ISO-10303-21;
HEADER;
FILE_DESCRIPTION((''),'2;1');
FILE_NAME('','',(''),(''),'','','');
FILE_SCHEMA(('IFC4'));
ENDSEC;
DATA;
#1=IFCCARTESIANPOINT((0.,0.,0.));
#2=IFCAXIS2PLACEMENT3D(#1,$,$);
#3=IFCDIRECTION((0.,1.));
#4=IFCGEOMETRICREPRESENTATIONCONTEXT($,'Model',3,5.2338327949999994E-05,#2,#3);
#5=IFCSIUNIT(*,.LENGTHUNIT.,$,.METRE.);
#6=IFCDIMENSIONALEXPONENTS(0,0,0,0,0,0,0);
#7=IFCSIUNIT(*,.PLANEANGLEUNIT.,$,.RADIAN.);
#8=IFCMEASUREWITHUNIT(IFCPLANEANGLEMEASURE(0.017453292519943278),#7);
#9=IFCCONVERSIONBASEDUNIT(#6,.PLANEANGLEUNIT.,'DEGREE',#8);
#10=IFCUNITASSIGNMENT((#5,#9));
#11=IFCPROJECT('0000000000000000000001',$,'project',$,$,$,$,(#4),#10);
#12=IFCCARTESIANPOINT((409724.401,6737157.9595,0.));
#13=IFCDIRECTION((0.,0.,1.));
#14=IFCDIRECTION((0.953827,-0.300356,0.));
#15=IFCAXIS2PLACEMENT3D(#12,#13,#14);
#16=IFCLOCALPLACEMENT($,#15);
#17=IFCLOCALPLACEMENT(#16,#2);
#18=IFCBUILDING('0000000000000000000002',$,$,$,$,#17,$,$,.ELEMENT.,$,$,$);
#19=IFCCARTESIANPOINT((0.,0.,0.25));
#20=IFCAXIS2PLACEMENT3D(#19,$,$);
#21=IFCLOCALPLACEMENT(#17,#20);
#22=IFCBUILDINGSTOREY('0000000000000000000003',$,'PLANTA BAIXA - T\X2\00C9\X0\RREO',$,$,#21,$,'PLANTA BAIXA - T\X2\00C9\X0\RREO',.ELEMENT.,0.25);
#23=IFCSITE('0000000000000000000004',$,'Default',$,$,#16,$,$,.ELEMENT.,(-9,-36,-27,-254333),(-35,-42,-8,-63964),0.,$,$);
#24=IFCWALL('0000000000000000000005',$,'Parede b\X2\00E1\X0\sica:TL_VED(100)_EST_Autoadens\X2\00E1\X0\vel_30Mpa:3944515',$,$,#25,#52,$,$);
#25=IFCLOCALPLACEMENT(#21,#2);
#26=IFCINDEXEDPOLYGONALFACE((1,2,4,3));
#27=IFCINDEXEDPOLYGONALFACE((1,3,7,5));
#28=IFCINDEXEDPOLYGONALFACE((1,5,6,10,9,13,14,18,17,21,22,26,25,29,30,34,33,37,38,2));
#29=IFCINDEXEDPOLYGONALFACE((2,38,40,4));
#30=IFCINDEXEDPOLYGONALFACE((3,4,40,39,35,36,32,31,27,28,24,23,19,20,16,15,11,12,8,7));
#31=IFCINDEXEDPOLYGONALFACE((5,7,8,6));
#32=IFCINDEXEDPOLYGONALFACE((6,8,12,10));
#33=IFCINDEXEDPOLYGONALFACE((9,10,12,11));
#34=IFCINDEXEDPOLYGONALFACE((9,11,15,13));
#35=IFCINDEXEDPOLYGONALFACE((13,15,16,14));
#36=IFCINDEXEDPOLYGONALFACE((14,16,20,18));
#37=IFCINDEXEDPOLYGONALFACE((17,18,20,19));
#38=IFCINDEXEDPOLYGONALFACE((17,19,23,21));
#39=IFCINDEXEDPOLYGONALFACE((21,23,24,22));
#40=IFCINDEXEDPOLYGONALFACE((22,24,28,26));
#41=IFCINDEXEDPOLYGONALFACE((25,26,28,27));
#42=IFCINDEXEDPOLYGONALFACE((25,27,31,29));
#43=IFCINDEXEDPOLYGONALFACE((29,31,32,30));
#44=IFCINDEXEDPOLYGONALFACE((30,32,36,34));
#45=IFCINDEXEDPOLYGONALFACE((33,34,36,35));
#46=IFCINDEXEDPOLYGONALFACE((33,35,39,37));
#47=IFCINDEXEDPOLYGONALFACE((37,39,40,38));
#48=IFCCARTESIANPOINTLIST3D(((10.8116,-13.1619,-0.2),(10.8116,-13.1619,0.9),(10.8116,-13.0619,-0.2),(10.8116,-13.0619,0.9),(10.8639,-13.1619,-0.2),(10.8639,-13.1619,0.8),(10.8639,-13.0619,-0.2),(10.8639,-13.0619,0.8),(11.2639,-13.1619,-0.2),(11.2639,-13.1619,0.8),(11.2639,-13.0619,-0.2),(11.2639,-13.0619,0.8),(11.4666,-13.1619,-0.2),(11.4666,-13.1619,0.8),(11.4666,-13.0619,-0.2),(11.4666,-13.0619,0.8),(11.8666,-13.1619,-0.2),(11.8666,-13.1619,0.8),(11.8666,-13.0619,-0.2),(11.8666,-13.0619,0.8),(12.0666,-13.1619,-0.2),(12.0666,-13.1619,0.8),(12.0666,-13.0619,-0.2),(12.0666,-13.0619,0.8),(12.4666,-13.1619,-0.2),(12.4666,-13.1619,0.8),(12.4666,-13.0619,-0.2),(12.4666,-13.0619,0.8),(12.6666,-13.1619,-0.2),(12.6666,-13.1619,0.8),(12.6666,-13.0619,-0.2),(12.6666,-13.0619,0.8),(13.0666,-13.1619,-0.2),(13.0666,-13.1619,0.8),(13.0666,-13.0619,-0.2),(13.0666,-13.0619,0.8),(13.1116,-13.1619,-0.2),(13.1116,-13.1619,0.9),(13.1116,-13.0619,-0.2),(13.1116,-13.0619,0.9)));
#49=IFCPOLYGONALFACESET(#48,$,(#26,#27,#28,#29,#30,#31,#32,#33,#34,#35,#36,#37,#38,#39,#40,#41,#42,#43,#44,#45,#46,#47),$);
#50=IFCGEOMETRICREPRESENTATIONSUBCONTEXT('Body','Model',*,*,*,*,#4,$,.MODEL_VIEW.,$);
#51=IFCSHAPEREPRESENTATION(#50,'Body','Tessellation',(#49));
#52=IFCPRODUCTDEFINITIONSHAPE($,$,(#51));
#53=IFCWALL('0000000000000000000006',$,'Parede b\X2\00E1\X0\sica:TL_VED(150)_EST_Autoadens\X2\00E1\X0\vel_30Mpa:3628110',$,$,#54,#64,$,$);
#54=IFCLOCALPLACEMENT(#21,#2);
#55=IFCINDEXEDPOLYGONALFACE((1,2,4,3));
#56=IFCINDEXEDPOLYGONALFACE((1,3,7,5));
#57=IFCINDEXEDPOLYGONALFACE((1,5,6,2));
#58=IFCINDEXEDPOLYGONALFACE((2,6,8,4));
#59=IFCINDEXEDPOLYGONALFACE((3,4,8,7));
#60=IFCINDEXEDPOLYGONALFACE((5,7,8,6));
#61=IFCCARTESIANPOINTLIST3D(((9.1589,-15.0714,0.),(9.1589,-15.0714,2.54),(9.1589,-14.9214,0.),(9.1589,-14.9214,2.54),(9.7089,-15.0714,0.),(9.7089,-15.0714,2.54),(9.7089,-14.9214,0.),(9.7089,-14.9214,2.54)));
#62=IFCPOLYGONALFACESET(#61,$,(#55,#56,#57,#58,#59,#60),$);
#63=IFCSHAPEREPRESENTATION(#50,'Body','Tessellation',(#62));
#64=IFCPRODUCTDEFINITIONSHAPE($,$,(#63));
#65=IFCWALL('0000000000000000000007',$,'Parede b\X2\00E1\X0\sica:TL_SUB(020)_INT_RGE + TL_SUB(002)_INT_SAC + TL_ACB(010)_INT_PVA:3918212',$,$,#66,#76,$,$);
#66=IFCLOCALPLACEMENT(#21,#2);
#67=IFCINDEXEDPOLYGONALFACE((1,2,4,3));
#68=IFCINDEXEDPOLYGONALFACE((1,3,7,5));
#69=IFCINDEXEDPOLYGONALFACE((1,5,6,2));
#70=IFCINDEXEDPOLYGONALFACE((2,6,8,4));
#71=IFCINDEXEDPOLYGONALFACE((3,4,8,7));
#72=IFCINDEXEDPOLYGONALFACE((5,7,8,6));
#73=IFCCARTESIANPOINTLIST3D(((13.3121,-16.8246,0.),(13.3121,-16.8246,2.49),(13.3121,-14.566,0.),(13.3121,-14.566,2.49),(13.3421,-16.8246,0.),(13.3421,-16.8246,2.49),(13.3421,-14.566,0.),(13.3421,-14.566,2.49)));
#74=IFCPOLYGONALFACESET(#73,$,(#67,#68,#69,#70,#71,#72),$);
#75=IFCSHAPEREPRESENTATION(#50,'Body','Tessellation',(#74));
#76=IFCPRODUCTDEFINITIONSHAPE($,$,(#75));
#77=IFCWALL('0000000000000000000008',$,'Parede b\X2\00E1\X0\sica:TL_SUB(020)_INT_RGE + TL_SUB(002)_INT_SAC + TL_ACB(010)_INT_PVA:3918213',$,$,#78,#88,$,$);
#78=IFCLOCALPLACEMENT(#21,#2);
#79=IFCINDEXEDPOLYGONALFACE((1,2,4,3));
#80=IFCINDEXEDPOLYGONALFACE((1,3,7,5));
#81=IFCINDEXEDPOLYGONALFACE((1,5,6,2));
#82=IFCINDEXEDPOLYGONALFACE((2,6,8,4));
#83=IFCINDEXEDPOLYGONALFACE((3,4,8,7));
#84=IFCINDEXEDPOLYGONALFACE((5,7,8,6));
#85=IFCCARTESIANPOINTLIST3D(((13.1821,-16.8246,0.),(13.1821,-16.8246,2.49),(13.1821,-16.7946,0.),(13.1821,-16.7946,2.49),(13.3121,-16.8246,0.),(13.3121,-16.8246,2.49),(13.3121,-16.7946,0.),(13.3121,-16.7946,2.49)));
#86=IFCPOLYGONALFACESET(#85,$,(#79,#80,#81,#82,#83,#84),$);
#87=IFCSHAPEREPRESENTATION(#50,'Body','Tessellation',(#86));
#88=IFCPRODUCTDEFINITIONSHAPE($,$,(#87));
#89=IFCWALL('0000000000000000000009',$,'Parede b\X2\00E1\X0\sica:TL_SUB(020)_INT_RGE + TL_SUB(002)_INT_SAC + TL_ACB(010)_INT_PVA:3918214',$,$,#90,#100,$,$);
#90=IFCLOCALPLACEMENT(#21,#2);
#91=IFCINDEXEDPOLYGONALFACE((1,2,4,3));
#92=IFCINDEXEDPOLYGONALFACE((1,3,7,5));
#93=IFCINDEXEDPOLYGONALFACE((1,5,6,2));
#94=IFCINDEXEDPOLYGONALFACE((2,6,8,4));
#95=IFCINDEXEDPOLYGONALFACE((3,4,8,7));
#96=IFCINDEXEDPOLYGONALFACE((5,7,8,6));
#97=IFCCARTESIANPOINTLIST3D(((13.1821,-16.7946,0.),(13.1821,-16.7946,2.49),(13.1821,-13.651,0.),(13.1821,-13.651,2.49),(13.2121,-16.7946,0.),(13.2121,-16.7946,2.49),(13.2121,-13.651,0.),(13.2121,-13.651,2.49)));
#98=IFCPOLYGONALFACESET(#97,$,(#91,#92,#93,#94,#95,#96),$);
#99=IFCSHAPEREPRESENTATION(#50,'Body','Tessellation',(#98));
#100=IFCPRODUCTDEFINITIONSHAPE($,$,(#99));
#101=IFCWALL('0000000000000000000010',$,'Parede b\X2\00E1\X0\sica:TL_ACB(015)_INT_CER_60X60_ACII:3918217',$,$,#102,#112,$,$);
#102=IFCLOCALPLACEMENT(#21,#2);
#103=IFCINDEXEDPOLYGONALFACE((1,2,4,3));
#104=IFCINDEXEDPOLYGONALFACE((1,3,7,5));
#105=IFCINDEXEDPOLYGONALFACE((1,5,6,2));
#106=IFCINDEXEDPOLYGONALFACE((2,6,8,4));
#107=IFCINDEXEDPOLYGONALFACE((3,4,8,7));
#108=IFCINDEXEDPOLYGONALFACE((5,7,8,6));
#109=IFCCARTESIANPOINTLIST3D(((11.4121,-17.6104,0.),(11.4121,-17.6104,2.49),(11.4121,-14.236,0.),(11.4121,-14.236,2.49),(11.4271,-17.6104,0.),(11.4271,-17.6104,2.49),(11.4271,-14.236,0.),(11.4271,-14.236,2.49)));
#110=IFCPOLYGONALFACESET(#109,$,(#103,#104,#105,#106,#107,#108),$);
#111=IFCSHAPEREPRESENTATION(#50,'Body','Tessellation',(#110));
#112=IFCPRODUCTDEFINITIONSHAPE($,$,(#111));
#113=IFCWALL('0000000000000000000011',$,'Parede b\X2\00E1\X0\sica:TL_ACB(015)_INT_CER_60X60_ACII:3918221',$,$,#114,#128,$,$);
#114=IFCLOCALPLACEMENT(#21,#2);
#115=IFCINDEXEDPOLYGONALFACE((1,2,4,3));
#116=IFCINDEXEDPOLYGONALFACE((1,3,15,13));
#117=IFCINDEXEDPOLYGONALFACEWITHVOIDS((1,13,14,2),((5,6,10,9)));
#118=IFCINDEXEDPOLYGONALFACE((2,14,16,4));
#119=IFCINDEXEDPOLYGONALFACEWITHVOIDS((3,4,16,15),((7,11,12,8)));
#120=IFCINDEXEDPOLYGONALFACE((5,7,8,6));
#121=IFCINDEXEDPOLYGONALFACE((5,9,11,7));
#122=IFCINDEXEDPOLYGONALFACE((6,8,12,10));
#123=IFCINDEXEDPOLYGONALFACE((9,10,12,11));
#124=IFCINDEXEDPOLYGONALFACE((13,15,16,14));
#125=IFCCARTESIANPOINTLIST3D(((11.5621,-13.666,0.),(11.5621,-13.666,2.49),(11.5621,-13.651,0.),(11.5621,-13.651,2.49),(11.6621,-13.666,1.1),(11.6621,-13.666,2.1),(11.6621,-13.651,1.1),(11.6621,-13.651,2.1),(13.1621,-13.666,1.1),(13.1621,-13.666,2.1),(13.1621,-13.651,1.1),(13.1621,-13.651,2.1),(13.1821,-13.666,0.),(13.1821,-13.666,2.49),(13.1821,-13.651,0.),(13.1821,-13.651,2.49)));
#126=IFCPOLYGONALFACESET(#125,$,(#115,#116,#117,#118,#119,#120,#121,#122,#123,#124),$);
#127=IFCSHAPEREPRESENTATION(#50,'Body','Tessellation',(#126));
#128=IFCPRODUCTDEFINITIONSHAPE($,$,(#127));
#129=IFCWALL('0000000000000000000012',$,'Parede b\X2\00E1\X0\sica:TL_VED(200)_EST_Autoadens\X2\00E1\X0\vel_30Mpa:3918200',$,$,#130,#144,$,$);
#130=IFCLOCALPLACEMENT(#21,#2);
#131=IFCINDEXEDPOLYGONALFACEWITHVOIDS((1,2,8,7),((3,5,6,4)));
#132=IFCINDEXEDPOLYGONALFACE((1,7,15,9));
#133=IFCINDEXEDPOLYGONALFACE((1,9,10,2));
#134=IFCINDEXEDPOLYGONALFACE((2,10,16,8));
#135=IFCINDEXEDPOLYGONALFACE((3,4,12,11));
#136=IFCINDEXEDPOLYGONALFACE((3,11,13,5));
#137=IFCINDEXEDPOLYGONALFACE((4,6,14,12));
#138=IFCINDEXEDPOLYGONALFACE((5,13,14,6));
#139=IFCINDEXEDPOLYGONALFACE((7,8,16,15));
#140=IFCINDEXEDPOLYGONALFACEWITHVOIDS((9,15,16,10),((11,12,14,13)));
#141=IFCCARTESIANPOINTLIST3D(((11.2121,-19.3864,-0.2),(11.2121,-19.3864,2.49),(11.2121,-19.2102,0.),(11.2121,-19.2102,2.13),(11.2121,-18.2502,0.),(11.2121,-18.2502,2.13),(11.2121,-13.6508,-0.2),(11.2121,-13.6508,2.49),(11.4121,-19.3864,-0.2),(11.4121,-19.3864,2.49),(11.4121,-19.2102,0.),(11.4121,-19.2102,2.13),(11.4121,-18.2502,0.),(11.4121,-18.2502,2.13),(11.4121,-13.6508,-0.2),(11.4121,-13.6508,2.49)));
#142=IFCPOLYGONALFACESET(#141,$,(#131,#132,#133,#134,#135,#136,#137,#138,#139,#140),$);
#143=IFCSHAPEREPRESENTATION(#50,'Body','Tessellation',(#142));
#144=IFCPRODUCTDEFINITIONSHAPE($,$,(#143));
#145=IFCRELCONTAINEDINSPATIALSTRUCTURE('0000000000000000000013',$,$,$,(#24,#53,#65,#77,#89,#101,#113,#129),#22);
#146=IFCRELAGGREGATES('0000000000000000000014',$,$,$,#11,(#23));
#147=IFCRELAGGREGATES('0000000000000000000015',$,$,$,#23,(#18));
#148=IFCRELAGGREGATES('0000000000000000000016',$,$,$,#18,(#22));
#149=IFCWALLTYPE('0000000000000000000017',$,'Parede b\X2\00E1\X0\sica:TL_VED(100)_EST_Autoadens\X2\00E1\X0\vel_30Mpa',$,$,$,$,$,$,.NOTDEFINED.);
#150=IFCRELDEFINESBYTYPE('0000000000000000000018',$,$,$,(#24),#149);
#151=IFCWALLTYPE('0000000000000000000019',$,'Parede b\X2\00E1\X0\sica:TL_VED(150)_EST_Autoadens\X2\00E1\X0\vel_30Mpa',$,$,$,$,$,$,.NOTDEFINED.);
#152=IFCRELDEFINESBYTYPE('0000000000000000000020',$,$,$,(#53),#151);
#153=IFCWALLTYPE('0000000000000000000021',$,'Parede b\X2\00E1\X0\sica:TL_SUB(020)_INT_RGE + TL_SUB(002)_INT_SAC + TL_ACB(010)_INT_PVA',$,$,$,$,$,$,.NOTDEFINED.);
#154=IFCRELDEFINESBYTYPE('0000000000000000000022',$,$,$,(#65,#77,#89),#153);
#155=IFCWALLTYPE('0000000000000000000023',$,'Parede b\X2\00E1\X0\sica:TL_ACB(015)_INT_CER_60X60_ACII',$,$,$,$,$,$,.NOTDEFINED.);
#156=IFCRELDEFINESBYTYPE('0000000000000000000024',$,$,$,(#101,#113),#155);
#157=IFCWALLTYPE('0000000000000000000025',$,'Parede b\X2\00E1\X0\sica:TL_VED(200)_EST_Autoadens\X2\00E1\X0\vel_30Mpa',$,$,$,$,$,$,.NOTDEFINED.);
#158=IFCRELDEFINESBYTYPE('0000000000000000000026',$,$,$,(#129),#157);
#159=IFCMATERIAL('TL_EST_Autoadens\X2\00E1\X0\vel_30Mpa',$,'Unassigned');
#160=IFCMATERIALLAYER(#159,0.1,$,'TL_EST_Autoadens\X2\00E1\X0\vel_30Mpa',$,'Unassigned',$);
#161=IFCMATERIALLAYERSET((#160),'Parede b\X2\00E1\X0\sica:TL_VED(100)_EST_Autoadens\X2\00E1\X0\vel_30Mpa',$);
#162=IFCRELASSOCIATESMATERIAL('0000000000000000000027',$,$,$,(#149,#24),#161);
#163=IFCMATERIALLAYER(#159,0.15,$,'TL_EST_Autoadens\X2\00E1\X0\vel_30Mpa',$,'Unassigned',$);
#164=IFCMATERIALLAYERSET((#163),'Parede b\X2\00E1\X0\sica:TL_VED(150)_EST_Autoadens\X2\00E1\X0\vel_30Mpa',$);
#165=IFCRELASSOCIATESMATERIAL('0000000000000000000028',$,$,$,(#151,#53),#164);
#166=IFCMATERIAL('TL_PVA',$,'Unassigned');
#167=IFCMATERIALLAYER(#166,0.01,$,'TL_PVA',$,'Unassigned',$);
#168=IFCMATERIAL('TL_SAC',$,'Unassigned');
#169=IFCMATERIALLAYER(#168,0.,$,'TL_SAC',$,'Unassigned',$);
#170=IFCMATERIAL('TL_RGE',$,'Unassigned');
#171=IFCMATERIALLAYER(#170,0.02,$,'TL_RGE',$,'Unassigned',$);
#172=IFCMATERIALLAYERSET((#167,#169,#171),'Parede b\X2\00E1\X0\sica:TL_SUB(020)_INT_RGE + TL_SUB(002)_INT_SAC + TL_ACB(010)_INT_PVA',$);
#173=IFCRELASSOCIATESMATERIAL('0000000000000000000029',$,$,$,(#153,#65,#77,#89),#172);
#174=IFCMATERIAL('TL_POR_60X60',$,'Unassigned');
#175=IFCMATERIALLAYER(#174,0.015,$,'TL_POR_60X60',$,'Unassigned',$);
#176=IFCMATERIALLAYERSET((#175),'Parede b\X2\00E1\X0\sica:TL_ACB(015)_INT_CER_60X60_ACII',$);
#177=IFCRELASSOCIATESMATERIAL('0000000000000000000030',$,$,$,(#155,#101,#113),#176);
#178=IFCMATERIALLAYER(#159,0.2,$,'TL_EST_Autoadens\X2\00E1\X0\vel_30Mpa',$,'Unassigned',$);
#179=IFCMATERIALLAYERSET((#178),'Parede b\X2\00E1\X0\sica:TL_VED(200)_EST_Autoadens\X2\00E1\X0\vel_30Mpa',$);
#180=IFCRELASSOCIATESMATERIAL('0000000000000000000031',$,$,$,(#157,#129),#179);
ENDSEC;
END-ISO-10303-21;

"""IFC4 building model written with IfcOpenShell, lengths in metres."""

from ifc_helpers import new_model, entity, si_unit, converted_unit, direction, frame, frame_2d, origin, place, context, subcontext, project, spatial, polyline, rectangle, extrude, clip, bounded_halfspace, material, layer, layer_set, layer_usage, type_object, element, save


model = new_model("IFC4")

# Units and contexts
model_context = context("Model", 3, precision=5.2338327949999994e-05, world=origin(), true_north=direction((0.0, 1.0)))
body_context = subcontext(model_context, "Body", "Model", "MODEL_VIEW")
ifc_project = project(units=[si_unit("LENGTHUNIT", "METRE"), converted_unit("PLANEANGLEUNIT", "DEGREE", entity("IfcPlaneAngleMeasure", 0.017453292519943278), si_unit("PLANEANGLEUNIT", "RADIAN"), dimensions=[0, 0, 0, 0, 0, 0, 0])], contexts=[model_context])

# Site, building, storey
site_placement = place(None, frame((409724.401, 6737157.9595, 0.0), z_axis=(0.0, 0.0, 1.0), x_axis=(0.953827, -0.300356, 0.0)))
site = spatial("IfcSite", under=ifc_project, at=site_placement, Name="Default", CompositionType="ELEMENT", RefLatitude=(-9, -36, -27, -254333), RefLongitude=(-35, -42, -8, -63964), RefElevation=0.0)
building_placement = place(site_placement, origin())
building = spatial("IfcBuilding", under=site, at=building_placement, CompositionType="ELEMENT")
storey_placement = place(building_placement, frame((0.0, 0.0, 0.25)))
storey = spatial("IfcBuildingStorey", under=building, at=storey_placement, Name="PLANTA BAIXA - TÉRREO", LongName="PLANTA BAIXA - TÉRREO", CompositionType="ELEMENT", Elevation=0.25)

# Shared definitions
ifc_material_1 = material(Name="TL_EST_Autoadensável_30Mpa", Category="Unassigned")
ifc_layer_1 = layer(ifc_material_1, 0.1, Name="TL_EST_Autoadensável_30Mpa", Category="Unassigned")
ifc_layer_set_1 = layer_set([ifc_layer_1], Name="Parede básica:TL_VED(100)_EST_Autoadensável_30Mpa")
wall_type_1 = type_object("IfcWallType", Name="Parede básica:TL_VED(100)_EST_Autoadensável_30Mpa", PredefinedType="NOTDEFINED", material=ifc_layer_set_1)

# Wall, openings
ifc_layer_usage_1 = layer_usage(ifc_layer_set_1, "AXIS2", "POSITIVE", -0.05)
wall_1_placement = place(storey_placement, frame((13.1116, -13.1119, -0.2), z_axis=(0.0, 0.0, 1.0), x_axis=(-1.0, 0.0, 0.0)))
wall_1 = element("IfcWall", 1, at=wall_1_placement, inside=storey, type_object=wall_type_1, material=ifc_layer_usage_1, Name="Parede básica:TL_VED(100)_EST_Autoadensável_30Mpa:3944515", context=body_context, shape_type="Clipping", body=[
    clip(extrude(rectangle(XDim=2.3, YDim=0.1, at=frame_2d((1.15, 0.0), x_axis=(1.0, 0.0))), origin(), (0.0, 0.0, 1.0), 1.1), bounded_halfspace(frame((0.0, -0.05, 1.1), z_axis=(0.0, 0.0, -1.0), x_axis=(-1.0, 0.0, 0.0)), True, frame((0.0, -0.05, 1.1)), polyline([(0.0, 0.0), (2.3, 0.0), (2.3, 0.05), (2.3, 0.1), (1.8027, 0.1), (1.7027, 0.1), (1.2, 0.1), (1.1, 0.1), (0.6, 0.1), (0.5, 0.1), (0.0, 0.1), (0.0, 0.0)]))),
])
opening_1_placement = place(wall_1_placement, frame((13.1116, -13.1119, 0.0), z_axis=(0.0, 0.0, 1.0), x_axis=(-1.0, 0.0, 0.0)))
element("IfcOpeningElement", 2, at=opening_1_placement, cuts=wall_1, PredefinedType="OPENING", context=body_context, shape_type="SweptSolid", body=[
    extrude(rectangle(XDim=1.0, YDim=0.4, at=frame_2d((0.0, 0.0), x_axis=(0.0, 1.0))), frame((11.0639, -12.3546, 0.5), z_axis=(0.0, -1.0, 0.0), x_axis=(-1.0, 0.0, 0.0)), (0.0, 0.0, 1.0), 1.542),
])
opening_2_placement = place(wall_1_placement, frame((13.1116, -13.1119, 0.0), z_axis=(0.0, 0.0, 1.0), x_axis=(-1.0, 0.0, 0.0)))
element("IfcOpeningElement", 3, at=opening_2_placement, cuts=wall_1, PredefinedType="OPENING", context=body_context, shape_type="SweptSolid", body=[
    extrude(rectangle(XDim=1.0, YDim=0.4, at=frame_2d((0.0, 0.0), x_axis=(0.0, 1.0))), frame((11.6666, -12.3546, 0.5), z_axis=(0.0, -1.0, 0.0), x_axis=(-1.0, 0.0, 0.0)), (0.0, 0.0, 1.0), 1.542),
])
opening_3_placement = place(wall_1_placement, frame((13.1116, -13.1119, 0.0), z_axis=(0.0, 0.0, 1.0), x_axis=(-1.0, 0.0, 0.0)))
element("IfcOpeningElement", 4, at=opening_3_placement, cuts=wall_1, PredefinedType="OPENING", context=body_context, shape_type="SweptSolid", body=[
    extrude(rectangle(XDim=1.0, YDim=0.4, at=frame_2d((0.0, 0.0), x_axis=(0.0, 1.0))), frame((12.2666, -12.3546, 0.5), z_axis=(0.0, -1.0, 0.0), x_axis=(-1.0, 0.0, 0.0)), (0.0, 0.0, 1.0), 1.542),
])
opening_4_placement = place(wall_1_placement, frame((13.1116, -13.1119, 0.0), z_axis=(0.0, 0.0, 1.0), x_axis=(-1.0, 0.0, 0.0)))
element("IfcOpeningElement", 5, at=opening_4_placement, cuts=wall_1, PredefinedType="OPENING", context=body_context, shape_type="SweptSolid", body=[
    extrude(rectangle(XDim=1.0, YDim=0.4, at=frame_2d((0.0, 0.0), x_axis=(0.0, 1.0))), frame((12.8666, -12.3546, 0.5), z_axis=(0.0, -1.0, 0.0), x_axis=(-1.0, 0.0, 0.0)), (0.0, 0.0, 1.0), 1.542),
])

# Walls
ifc_layer_2 = layer(ifc_material_1, 0.15, Name="TL_EST_Autoadensável_30Mpa", Category="Unassigned")
ifc_layer_set_2 = layer_set([ifc_layer_2], Name="Parede básica:TL_VED(150)_EST_Autoadensável_30Mpa")
ifc_layer_usage_2 = layer_usage(ifc_layer_set_2, "AXIS2", "NEGATIVE", 0.075)
wall_type_2 = type_object("IfcWallType", Name="Parede básica:TL_VED(150)_EST_Autoadensável_30Mpa", PredefinedType="NOTDEFINED", material=ifc_layer_set_2)
wall_2_placement = place(storey_placement, frame((9.1589, -14.9964, 0.0)))
element("IfcWall", 6, at=wall_2_placement, inside=storey, type_object=wall_type_2, material=ifc_layer_usage_2, Name="Parede básica:TL_VED(150)_EST_Autoadensável_30Mpa:3628110", context=body_context, shape_type="SweptSolid", body=[
    extrude(rectangle(XDim=0.55, YDim=0.15, at=frame_2d((0.275, 0.0), x_axis=(-1.0, 0.0))), origin(), (0.0, 0.0, 1.0), 2.54),
])
ifc_material_2 = material(Name="TL_PVA", Category="Unassigned")
ifc_layer_3 = layer(ifc_material_2, 0.01, Name="TL_PVA", Category="Unassigned")
ifc_material_3 = material(Name="TL_SAC", Category="Unassigned")
ifc_layer_4 = layer(ifc_material_3, 0.0, Name="TL_SAC", Category="Unassigned")
ifc_material_4 = material(Name="TL_RGE", Category="Unassigned")
ifc_layer_5 = layer(ifc_material_4, 0.02, Name="TL_RGE", Category="Unassigned")
ifc_layer_set_3 = layer_set([ifc_layer_3, ifc_layer_4, ifc_layer_5], Name="Parede básica:TL_SUB(020)_INT_RGE + TL_SUB(002)_INT_SAC + TL_ACB(010)_INT_PVA")
ifc_layer_usage_3 = layer_usage(ifc_layer_set_3, "AXIS2", "POSITIVE", -0.015)
wall_type_3 = type_object("IfcWallType", Name="Parede básica:TL_SUB(020)_INT_RGE + TL_SUB(002)_INT_SAC + TL_ACB(010)_INT_PVA", PredefinedType="NOTDEFINED", material=ifc_layer_set_3)
wall_3_placement = place(storey_placement, frame((13.3271, -16.8246, 0.0), z_axis=(0.0, 0.0, 1.0), x_axis=(0.0, 1.0, 0.0)))
element("IfcWall", 7, at=wall_3_placement, inside=storey, type_object=wall_type_3, material=ifc_layer_usage_3, Name="Parede básica:TL_SUB(020)_INT_RGE + TL_SUB(002)_INT_SAC + TL_ACB(010)_INT_PVA:3918212", context=body_context, shape_type="SweptSolid", body=[
    extrude(rectangle(XDim=2.2587, YDim=0.03, at=frame_2d((1.1293, 0.0), x_axis=(-1.0, 0.0))), origin(), (0.0, 0.0, 1.0), 2.49),
])
ifc_layer_usage_4 = layer_usage(ifc_layer_set_3, "AXIS2", "POSITIVE", -0.015)
wall_4_placement = place(storey_placement, frame((13.1821, -16.8096, 0.0)))
element("IfcWall", 8, at=wall_4_placement, inside=storey, type_object=wall_type_3, material=ifc_layer_usage_4, Name="Parede básica:TL_SUB(020)_INT_RGE + TL_SUB(002)_INT_SAC + TL_ACB(010)_INT_PVA:3918213", context=body_context, shape_type="SweptSolid", body=[
    extrude(rectangle(XDim=0.13, YDim=0.03, at=frame_2d((0.065, 0.0), x_axis=(-1.0, 0.0))), origin(), (0.0, 0.0, 1.0), 2.49),
])
ifc_layer_usage_5 = layer_usage(ifc_layer_set_3, "AXIS2", "POSITIVE", -0.015)
wall_5_placement = place(storey_placement, frame((13.1971, -13.651, 0.0), z_axis=(0.0, 0.0, 1.0), x_axis=(0.0, -1.0, 0.0)))
element("IfcWall", 9, at=wall_5_placement, inside=storey, type_object=wall_type_3, material=ifc_layer_usage_5, Name="Parede básica:TL_SUB(020)_INT_RGE + TL_SUB(002)_INT_SAC + TL_ACB(010)_INT_PVA:3918214", context=body_context, shape_type="SweptSolid", body=[
    extrude(rectangle(XDim=3.1437, YDim=0.03, at=frame_2d((1.5718, 0.0), x_axis=(-1.0, 0.0))), origin(), (0.0, 0.0, 1.0), 2.49),
])
ifc_material_5 = material(Name="TL_POR_60X60", Category="Unassigned")
ifc_layer_6 = layer(ifc_material_5, 0.015, Name="TL_POR_60X60", Category="Unassigned")
ifc_layer_set_4 = layer_set([ifc_layer_6], Name="Parede básica:TL_ACB(015)_INT_CER_60X60_ACII")
ifc_layer_usage_6 = layer_usage(ifc_layer_set_4, "AXIS2", "POSITIVE", -0.0075)
wall_type_4 = type_object("IfcWallType", Name="Parede básica:TL_ACB(015)_INT_CER_60X60_ACII", PredefinedType="NOTDEFINED", material=ifc_layer_set_4)
wall_6_placement = place(storey_placement, frame((11.4196, -17.6104, 0.0), z_axis=(0.0, 0.0, 1.0), x_axis=(0.0, 1.0, 0.0)))
element("IfcWall", 10, at=wall_6_placement, inside=storey, type_object=wall_type_4, material=ifc_layer_usage_6, Name="Parede básica:TL_ACB(015)_INT_CER_60X60_ACII:3918217", context=body_context, shape_type="SweptSolid", body=[
    extrude(rectangle(XDim=3.3744, YDim=0.015, at=frame_2d((1.6872, 0.0), x_axis=(-1.0, 0.0))), origin(), (0.0, 0.0, 1.0), 2.49),
])

# Walls, openings
ifc_layer_usage_7 = layer_usage(ifc_layer_set_4, "AXIS2", "POSITIVE", -0.0075)
wall_7_placement = place(storey_placement, frame((11.5621, -13.6585, 0.0)))
wall_7 = element("IfcWall", 11, at=wall_7_placement, inside=storey, type_object=wall_type_4, material=ifc_layer_usage_7, Name="Parede básica:TL_ACB(015)_INT_CER_60X60_ACII:3918221", context=body_context, shape_type="SweptSolid", body=[
    extrude(rectangle(XDim=1.62, YDim=0.015, at=frame_2d((0.81, 0.0), x_axis=(-1.0, 0.0))), origin(), (0.0, 0.0, 1.0), 2.49),
])
opening_5_placement = place(wall_7_placement, frame((-11.5621, 13.6585, 1.1)))
element("IfcOpeningElement", 12, at=opening_5_placement, cuts=wall_7, PredefinedType="OPENING", context=body_context, shape_type="SweptSolid", body=[
    extrude(rectangle(XDim=1.0, YDim=1.5, at=frame_2d((0.0, 0.0), x_axis=(0.0, 1.0))), frame((12.4121, -15.175, 0.5), z_axis=(0.0, 1.0, 0.0), x_axis=(1.0, 0.0, 0.0)), (0.0, 0.0, 1.0), 3.048),
])
ifc_layer_7 = layer(ifc_material_1, 0.2, Name="TL_EST_Autoadensável_30Mpa", Category="Unassigned")
ifc_layer_set_5 = layer_set([ifc_layer_7], Name="Parede básica:TL_VED(200)_EST_Autoadensável_30Mpa")
ifc_layer_usage_8 = layer_usage(ifc_layer_set_5, "AXIS2", "POSITIVE", -0.1)
wall_type_5 = type_object("IfcWallType", Name="Parede básica:TL_VED(200)_EST_Autoadensável_30Mpa", PredefinedType="NOTDEFINED", material=ifc_layer_set_5)
wall_8_placement = place(storey_placement, frame((11.3121, -13.6508, -0.2), z_axis=(0.0, 0.0, 1.0), x_axis=(0.0, -1.0, 0.0)))
wall_8 = element("IfcWall", 13, at=wall_8_placement, inside=storey, type_object=wall_type_5, material=ifc_layer_usage_8, Name="Parede básica:TL_VED(200)_EST_Autoadensável_30Mpa:3918200", context=body_context, shape_type="SweptSolid", body=[
    extrude(rectangle(XDim=5.7355, YDim=0.2, at=frame_2d((2.8678, 0.0), x_axis=(-1.0, 0.0))), origin(), (0.0, 0.0, 1.0), 2.69),
])
opening_6_placement = place(wall_8_placement, frame((4.5993, -0.1, 0.2)))
element("IfcOpeningElement", 14, at=opening_6_placement, cuts=wall_8, PredefinedType="OPENING", context=body_context, shape_type="SweptSolid", body=[
    extrude(rectangle(XDim=2.13, YDim=0.96, at=frame_2d((1.065, 0.48), x_axis=(1.0, 0.0))), frame((0.0, 0.0, 0.0), z_axis=(0.0, 1.0, 0.0), x_axis=(0.0, 0.0, 1.0)), (0.0, 0.0, 1.0), 0.2),
])

save(model, "model.ifc")
